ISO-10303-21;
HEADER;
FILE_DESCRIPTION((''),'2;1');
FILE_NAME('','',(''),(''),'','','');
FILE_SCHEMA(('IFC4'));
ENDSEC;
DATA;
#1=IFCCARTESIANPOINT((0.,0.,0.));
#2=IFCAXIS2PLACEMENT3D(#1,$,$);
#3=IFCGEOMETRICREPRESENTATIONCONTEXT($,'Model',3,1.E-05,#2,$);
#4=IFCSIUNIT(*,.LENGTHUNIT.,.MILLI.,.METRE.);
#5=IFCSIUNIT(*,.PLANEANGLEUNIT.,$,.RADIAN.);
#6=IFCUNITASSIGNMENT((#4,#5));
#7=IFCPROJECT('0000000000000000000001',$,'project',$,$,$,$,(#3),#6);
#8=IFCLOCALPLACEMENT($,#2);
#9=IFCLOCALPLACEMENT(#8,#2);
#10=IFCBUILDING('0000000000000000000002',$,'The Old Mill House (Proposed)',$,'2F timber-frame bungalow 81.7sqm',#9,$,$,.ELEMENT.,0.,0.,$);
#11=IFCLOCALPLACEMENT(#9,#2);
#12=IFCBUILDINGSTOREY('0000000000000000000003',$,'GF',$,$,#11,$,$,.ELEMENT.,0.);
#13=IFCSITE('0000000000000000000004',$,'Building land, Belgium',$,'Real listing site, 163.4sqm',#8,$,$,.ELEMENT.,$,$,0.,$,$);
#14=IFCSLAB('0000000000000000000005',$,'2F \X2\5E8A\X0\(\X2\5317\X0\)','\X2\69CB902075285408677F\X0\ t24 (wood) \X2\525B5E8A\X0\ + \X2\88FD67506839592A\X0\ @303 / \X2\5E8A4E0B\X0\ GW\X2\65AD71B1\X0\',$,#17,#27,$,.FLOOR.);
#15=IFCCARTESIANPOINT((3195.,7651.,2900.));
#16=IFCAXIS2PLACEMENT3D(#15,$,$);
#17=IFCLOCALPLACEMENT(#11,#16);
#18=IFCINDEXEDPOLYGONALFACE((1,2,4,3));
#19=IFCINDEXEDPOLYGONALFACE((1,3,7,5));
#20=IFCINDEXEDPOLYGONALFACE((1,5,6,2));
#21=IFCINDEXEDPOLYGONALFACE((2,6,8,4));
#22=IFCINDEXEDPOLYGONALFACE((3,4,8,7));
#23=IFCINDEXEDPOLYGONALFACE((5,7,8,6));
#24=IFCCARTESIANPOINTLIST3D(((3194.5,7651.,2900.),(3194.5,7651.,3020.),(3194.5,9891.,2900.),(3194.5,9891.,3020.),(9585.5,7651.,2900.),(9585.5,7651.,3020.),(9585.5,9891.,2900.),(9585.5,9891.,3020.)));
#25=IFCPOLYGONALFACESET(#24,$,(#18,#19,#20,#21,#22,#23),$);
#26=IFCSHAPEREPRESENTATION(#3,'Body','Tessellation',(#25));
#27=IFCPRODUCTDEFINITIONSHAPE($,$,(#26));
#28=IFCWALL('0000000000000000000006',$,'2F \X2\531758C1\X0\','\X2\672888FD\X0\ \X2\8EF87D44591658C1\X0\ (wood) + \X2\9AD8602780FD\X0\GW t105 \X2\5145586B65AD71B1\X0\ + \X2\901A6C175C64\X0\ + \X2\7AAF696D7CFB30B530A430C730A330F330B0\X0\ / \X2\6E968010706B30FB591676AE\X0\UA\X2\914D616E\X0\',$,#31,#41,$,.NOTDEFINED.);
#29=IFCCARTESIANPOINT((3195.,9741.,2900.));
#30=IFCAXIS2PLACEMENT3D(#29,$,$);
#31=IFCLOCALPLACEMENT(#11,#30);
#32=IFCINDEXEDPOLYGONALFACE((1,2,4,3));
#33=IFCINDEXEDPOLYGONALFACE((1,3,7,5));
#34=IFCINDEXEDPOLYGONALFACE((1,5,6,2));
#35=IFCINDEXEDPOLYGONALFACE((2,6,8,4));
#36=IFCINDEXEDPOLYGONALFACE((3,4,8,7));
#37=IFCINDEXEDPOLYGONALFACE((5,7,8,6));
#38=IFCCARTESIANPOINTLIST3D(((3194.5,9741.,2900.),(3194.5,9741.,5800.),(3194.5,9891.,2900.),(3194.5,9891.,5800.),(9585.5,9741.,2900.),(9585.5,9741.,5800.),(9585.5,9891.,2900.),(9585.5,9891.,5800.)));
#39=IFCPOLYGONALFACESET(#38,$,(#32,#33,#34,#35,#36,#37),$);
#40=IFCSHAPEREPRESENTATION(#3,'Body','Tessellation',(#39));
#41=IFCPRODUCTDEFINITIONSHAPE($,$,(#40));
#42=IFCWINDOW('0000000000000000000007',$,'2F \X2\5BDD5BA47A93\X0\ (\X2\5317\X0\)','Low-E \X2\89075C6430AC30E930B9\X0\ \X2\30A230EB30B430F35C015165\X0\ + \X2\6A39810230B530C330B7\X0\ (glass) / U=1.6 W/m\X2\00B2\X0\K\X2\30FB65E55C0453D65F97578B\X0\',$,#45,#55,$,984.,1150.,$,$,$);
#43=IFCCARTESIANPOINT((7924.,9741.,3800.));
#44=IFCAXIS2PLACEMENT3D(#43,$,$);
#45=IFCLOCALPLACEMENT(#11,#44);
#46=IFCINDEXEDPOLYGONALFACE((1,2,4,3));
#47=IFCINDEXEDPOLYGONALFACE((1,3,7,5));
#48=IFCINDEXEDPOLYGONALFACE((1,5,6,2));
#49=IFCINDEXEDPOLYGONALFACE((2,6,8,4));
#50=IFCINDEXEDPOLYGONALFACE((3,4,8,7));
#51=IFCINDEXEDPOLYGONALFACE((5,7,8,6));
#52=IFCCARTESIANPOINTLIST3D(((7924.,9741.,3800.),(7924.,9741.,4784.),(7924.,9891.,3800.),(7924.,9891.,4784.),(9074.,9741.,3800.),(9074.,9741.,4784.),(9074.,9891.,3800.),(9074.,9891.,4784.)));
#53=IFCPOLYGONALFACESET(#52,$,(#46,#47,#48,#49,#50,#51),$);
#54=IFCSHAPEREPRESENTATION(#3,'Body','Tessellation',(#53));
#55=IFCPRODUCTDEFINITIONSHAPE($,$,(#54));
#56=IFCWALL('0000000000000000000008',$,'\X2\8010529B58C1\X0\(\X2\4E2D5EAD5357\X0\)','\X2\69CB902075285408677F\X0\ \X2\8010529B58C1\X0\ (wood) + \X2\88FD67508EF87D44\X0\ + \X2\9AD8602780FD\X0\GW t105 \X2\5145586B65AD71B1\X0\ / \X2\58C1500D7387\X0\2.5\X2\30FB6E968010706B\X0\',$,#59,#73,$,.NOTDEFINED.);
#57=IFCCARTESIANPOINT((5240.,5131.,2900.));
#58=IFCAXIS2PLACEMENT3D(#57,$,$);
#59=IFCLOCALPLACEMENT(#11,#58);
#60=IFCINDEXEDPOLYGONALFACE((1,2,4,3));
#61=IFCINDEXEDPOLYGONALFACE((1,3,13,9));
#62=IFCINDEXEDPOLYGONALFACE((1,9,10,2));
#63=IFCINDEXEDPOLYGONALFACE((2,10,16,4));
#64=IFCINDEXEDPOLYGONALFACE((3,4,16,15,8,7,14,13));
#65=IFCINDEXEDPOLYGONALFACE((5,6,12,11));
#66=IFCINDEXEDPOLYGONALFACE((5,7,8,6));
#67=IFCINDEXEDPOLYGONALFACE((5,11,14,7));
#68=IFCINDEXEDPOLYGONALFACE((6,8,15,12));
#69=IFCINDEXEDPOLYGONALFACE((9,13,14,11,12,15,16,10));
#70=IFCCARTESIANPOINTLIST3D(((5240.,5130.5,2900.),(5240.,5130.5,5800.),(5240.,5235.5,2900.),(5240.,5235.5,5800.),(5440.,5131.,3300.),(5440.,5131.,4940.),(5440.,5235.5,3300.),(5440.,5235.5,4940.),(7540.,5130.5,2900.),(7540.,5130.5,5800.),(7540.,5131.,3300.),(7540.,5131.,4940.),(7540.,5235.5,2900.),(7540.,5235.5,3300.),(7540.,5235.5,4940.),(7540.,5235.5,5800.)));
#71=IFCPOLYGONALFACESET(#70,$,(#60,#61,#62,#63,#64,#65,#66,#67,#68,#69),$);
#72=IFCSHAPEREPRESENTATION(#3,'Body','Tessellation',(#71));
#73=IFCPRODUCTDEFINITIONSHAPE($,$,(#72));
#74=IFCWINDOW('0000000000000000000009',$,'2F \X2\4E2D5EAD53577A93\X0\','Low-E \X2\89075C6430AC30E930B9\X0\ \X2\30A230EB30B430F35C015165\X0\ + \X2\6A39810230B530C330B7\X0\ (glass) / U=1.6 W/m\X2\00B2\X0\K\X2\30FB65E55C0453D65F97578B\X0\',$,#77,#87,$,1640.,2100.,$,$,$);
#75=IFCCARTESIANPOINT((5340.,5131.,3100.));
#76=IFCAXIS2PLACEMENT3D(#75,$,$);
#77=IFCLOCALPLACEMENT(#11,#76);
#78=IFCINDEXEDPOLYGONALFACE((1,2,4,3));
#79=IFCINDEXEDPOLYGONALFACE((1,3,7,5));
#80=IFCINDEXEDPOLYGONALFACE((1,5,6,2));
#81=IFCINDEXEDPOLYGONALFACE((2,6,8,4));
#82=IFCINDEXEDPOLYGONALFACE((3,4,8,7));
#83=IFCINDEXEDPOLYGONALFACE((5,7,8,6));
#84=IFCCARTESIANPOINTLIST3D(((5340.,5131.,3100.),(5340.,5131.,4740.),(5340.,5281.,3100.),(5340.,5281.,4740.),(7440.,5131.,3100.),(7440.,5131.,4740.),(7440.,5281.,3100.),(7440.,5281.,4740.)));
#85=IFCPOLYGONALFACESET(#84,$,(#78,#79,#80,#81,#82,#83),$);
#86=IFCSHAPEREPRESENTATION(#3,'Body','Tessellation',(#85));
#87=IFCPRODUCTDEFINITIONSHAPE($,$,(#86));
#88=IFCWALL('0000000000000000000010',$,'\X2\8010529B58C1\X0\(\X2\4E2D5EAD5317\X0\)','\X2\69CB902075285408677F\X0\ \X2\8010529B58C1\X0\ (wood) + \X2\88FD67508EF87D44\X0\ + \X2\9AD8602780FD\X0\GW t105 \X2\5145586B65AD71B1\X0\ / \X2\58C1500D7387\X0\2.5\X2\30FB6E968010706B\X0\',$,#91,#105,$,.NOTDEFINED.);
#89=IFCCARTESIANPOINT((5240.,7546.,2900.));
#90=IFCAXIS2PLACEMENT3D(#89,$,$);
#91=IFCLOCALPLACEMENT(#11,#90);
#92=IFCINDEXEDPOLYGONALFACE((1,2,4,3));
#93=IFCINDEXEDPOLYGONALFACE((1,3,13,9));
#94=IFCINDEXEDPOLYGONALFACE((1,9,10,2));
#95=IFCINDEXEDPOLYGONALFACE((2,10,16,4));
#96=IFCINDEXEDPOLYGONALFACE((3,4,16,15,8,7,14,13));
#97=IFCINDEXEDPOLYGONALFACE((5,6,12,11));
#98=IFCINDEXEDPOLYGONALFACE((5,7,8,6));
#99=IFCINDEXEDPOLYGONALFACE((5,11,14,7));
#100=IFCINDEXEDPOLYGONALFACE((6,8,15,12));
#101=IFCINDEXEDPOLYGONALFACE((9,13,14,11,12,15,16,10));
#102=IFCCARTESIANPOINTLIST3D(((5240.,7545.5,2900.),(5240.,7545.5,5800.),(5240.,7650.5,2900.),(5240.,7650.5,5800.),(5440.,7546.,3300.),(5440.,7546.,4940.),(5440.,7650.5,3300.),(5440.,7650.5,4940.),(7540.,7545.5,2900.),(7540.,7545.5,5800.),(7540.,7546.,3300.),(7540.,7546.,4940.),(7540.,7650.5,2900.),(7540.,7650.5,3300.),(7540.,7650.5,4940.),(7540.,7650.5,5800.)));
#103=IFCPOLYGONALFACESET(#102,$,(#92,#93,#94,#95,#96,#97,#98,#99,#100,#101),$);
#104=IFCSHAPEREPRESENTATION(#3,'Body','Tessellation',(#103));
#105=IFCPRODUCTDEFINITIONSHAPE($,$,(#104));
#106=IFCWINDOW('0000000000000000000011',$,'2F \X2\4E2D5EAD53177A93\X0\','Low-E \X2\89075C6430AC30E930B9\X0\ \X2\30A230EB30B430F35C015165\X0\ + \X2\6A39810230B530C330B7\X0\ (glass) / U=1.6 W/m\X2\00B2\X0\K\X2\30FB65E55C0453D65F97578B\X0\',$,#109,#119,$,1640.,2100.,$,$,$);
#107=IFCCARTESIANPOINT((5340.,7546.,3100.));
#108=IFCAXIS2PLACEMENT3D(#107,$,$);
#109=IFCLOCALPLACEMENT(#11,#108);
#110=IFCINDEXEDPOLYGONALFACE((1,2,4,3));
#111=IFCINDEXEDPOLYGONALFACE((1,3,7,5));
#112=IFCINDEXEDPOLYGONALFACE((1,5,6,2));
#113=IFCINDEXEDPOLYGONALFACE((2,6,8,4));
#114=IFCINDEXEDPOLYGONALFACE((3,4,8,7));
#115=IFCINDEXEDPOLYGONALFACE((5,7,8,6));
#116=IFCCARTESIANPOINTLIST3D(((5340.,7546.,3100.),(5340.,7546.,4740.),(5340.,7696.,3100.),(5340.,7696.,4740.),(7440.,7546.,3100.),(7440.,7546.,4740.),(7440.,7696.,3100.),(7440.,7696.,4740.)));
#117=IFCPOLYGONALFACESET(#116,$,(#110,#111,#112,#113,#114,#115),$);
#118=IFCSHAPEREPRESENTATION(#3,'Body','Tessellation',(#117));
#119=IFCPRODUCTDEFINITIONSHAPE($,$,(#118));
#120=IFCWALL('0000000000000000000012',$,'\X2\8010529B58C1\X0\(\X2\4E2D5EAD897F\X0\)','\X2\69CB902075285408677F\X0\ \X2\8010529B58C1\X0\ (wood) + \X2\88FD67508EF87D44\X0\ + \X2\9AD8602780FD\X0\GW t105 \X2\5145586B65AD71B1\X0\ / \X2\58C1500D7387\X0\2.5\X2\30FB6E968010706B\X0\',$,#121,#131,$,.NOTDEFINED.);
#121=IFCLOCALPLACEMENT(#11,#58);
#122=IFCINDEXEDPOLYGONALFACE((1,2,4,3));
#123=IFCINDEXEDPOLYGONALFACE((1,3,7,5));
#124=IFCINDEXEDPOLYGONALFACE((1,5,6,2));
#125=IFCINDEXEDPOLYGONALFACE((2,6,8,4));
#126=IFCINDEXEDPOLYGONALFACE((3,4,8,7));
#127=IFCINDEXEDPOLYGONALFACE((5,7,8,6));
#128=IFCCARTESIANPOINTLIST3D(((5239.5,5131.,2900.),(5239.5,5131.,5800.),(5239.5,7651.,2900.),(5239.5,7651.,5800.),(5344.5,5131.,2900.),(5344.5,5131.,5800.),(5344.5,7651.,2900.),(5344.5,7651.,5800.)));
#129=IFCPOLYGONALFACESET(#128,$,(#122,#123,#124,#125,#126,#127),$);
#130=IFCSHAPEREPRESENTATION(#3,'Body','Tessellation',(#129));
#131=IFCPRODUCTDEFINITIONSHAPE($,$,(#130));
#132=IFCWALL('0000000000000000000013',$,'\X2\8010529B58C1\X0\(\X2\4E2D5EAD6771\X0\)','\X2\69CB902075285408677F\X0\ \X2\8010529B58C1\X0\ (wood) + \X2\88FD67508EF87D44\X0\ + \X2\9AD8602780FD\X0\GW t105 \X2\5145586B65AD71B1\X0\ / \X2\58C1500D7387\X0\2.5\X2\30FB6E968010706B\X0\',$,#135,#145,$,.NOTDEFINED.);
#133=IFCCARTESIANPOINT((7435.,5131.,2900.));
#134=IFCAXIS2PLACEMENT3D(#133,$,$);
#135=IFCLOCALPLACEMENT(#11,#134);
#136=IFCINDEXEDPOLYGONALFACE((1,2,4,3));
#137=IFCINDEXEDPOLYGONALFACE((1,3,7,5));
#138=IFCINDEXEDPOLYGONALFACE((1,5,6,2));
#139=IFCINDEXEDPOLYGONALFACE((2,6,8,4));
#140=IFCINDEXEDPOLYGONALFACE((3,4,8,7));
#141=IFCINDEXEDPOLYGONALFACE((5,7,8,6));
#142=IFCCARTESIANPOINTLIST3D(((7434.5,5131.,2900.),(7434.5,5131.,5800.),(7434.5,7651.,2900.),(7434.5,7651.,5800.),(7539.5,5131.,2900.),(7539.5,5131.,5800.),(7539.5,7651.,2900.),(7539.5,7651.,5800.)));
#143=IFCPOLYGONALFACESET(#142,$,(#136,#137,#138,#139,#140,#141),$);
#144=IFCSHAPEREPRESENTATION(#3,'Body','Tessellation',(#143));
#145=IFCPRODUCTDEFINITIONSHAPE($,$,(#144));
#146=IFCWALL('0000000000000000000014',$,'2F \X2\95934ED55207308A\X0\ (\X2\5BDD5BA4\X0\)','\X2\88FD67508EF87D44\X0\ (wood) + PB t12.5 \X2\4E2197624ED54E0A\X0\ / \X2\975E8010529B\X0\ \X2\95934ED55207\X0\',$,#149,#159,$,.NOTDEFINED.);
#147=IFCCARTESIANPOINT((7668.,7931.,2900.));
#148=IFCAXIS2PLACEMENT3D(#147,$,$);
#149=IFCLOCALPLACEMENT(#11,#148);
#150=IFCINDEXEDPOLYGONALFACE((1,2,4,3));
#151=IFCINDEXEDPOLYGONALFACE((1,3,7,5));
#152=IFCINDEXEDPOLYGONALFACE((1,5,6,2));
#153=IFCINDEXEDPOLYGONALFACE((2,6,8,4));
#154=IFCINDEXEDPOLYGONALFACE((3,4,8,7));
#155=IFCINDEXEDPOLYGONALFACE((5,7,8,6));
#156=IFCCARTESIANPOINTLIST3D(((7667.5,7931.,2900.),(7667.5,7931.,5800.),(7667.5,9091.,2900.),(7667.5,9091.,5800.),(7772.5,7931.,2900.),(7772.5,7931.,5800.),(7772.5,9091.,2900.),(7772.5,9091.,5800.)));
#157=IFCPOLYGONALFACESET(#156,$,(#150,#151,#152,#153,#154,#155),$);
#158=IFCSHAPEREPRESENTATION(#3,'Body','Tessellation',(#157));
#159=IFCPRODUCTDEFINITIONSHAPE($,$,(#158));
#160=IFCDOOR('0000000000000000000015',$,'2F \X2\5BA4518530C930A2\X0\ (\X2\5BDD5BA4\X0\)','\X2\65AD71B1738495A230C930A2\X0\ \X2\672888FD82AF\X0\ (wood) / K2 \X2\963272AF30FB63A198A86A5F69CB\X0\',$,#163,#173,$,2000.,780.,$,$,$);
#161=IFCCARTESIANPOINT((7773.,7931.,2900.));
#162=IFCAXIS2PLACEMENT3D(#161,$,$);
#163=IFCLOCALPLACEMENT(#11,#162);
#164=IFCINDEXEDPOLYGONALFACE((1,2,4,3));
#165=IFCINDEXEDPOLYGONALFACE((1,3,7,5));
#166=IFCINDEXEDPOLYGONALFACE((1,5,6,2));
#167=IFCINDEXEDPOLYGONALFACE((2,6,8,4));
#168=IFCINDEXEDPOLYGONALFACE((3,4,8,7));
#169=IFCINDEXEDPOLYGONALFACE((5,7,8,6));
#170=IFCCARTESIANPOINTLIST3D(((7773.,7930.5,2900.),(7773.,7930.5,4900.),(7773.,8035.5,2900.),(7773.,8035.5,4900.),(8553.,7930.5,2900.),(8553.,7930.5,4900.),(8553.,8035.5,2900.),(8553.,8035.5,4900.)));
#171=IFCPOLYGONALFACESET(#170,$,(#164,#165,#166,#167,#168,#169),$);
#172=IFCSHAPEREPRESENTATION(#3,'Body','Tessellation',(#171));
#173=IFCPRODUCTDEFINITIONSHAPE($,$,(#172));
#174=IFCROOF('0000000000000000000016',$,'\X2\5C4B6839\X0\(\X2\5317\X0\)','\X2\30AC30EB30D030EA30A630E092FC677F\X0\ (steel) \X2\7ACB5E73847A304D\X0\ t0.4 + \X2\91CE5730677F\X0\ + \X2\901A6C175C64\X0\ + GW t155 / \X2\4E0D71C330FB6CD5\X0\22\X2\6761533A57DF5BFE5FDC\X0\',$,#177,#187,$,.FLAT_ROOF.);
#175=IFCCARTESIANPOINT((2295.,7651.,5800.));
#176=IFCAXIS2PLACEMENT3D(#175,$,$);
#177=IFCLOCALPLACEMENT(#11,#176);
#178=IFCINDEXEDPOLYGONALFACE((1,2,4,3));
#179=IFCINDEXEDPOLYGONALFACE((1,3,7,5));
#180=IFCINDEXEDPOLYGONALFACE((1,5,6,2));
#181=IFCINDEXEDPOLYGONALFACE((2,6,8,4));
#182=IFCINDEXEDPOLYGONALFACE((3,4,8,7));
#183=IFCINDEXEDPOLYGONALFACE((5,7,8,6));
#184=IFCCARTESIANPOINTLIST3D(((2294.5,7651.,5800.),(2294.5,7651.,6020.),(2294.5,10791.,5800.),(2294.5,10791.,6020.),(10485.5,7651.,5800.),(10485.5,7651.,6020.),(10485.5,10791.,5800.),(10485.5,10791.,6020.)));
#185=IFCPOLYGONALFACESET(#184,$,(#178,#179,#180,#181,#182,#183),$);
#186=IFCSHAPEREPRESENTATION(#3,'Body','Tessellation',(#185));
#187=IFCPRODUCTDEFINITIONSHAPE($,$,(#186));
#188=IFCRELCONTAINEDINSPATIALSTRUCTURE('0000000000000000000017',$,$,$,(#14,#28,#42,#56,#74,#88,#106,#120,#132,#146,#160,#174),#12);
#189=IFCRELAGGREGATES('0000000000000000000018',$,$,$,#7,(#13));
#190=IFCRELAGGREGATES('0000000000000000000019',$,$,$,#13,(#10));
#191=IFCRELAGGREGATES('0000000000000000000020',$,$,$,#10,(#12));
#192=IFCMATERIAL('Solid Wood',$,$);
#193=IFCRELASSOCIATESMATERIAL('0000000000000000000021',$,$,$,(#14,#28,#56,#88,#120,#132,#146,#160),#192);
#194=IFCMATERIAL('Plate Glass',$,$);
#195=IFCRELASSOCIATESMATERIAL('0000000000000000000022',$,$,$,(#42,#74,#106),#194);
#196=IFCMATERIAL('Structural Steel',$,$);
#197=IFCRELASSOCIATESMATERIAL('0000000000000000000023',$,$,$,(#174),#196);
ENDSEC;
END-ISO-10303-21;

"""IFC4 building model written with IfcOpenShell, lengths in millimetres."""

from ifc_helpers import new_model, si_unit, frame, frame_2d, origin, place, context, project, spatial, rectangle, extrude, material, element, fill, save


model = new_model("IFC4")

# Units and contexts
model_context = context("Model", 3, precision=1e-05, world=origin())
ifc_project = project(units=[si_unit("LENGTHUNIT", "METRE", prefix="MILLI"), si_unit("PLANEANGLEUNIT", "RADIAN")], contexts=[model_context])

# Site, building, storey
site_placement = place(None, origin())
site = spatial("IfcSite", under=ifc_project, at=site_placement, Name="Building land, Belgium", ObjectType="Real listing site, 163.4sqm", CompositionType="ELEMENT", RefElevation=0.0)
building_placement = place(site_placement, origin())
building = spatial("IfcBuilding", under=site, at=building_placement, Name="The Old Mill House (Proposed)", ObjectType="2F timber-frame bungalow 81.7sqm", CompositionType="ELEMENT", ElevationOfRefHeight=0.0, ElevationOfTerrain=0.0)
storey_placement = place(building_placement, origin())
storey = spatial("IfcBuildingStorey", under=building, at=storey_placement, Name="GF", CompositionType="ELEMENT", Elevation=0.0)

# Slab
ifc_material_1 = material(Name="Solid Wood")
slab_placement = place(storey_placement, frame((3195.0, 7651.0, 2900.0)))
element("IfcSlab", 1, at=slab_placement, inside=storey, material=ifc_material_1, Name="2F 床(北)", Description="構造用合板 t24 (wood) 剛床 + 製材根太 @303 / 床下 GW断熱", PredefinedType="FLOOR", context=model_context, shape_type="SweptSolid", body=[
    extrude(rectangle(XDim=6391.0, YDim=2240.0, at=frame_2d((3195.0, 1120.0))), frame((3195.0, 7651.0, 2900.0)), (0.0, 0.0, 1.0), 120.0),
])

# Walls, openings, windows
wall_1_placement = place(storey_placement, frame((3195.0, 9741.0, 2900.0)))
wall_1 = element("IfcWall", 2, at=wall_1_placement, inside=storey, material=ifc_material_1, Name="2F 北壁", Description="木製 軸組外壁 (wood) + 高性能GW t105 充填断熱 + 通気層 + 窯業系サイディング / 準耐火・外皮UA配慮", PredefinedType="NOTDEFINED", context=model_context, shape_type="SweptSolid", body=[
    extrude(rectangle(XDim=6391.0, YDim=150.0, at=frame_2d((3195.0, 75.0))), frame((3195.0, 9741.0, 2900.0)), (0.0, 0.0, 1.0), 2900.0),
])
opening_1_placement = place(storey_placement, frame((7924.0, 9741.0, 3800.0)))
opening_1 = element("IfcOpeningElement", 3, at=opening_1_placement, cuts=wall_1, PredefinedType="NOTDEFINED", context=model_context, shape_type="SweptSolid", body=[
    extrude(rectangle(XDim=1150.0, YDim=150.0, at=frame_2d((575.0, 75.0))), frame((7924.0, 9741.0, 3800.0)), (0.0, 0.0, 1.0), 984.0),
])
ifc_material_2 = material(Name="Plate Glass")
window_1_placement = place(storey_placement, frame((7924.0, 9741.0, 3800.0)))
window_1 = element("IfcWindow", 4, at=window_1_placement, inside=storey, material=ifc_material_2, Name="2F 寝室窓 (北)", Description="Low-E 複層ガラス アルゴン封入 + 樹脂サッシ (glass) / U=1.6 W/m²K・日射取得型", OverallHeight=984.0, OverallWidth=1150.0, context=model_context, shape_type="SweptSolid", body=[
    extrude(rectangle(XDim=1150.0, YDim=150.0, at=frame_2d((575.0, 75.0))), frame((7924.0, 9741.0, 3800.0)), (0.0, 0.0, 1.0), 984.0),
])
fill(opening_1, window_1)
wall_2_placement = place(storey_placement, frame((5240.0, 5131.0, 2900.0)))
wall_2 = element("IfcWall", 5, at=wall_2_placement, inside=storey, material=ifc_material_1, Name="耐力壁(中庭南)", Description="構造用合板 耐力壁 (wood) + 製材軸組 + 高性能GW t105 充填断熱 / 壁倍率2.5・準耐火", PredefinedType="NOTDEFINED", context=model_context, shape_type="SweptSolid", body=[
    extrude(rectangle(XDim=2300.0, YDim=105.0, at=frame_2d((1150.0, 52.0))), frame((5240.0, 5131.0, 2900.0)), (0.0, 0.0, 1.0), 2900.0),
])
opening_2_placement = place(storey_placement, frame((5340.0, 5131.0, 3100.0)))
opening_2 = element("IfcOpeningElement", 6, at=opening_2_placement, cuts=wall_2, PredefinedType="NOTDEFINED", context=model_context, shape_type="SweptSolid", body=[
    extrude(rectangle(XDim=2100.0, YDim=150.0, at=frame_2d((1050.0, 75.0))), frame((5340.0, 5131.0, 3100.0)), (0.0, 0.0, 1.0), 1640.0),
])
window_2_placement = place(storey_placement, frame((5340.0, 5131.0, 3100.0)))
window_2 = element("IfcWindow", 7, at=window_2_placement, inside=storey, material=ifc_material_2, Name="2F 中庭南窓", Description="Low-E 複層ガラス アルゴン封入 + 樹脂サッシ (glass) / U=1.6 W/m²K・日射取得型", OverallHeight=1640.0, OverallWidth=2100.0, context=model_context, shape_type="SweptSolid", body=[
    extrude(rectangle(XDim=2100.0, YDim=150.0, at=frame_2d((1050.0, 75.0))), frame((5340.0, 5131.0, 3100.0)), (0.0, 0.0, 1.0), 1640.0),
])
fill(opening_2, window_2)
wall_3_placement = place(storey_placement, frame((5240.0, 7546.0, 2900.0)))
wall_3 = element("IfcWall", 8, at=wall_3_placement, inside=storey, material=ifc_material_1, Name="耐力壁(中庭北)", Description="構造用合板 耐力壁 (wood) + 製材軸組 + 高性能GW t105 充填断熱 / 壁倍率2.5・準耐火", PredefinedType="NOTDEFINED", context=model_context, shape_type="SweptSolid", body=[
    extrude(rectangle(XDim=2300.0, YDim=105.0, at=frame_2d((1150.0, 52.0))), frame((5240.0, 7546.0, 2900.0)), (0.0, 0.0, 1.0), 2900.0),
])
opening_3_placement = place(storey_placement, frame((5340.0, 7546.0, 3100.0)))
opening_3 = element("IfcOpeningElement", 9, at=opening_3_placement, cuts=wall_3, PredefinedType="NOTDEFINED", context=model_context, shape_type="SweptSolid", body=[
    extrude(rectangle(XDim=2100.0, YDim=150.0, at=frame_2d((1050.0, 75.0))), frame((5340.0, 7546.0, 3100.0)), (0.0, 0.0, 1.0), 1640.0),
])
window_3_placement = place(storey_placement, frame((5340.0, 7546.0, 3100.0)))
window_3 = element("IfcWindow", 10, at=window_3_placement, inside=storey, material=ifc_material_2, Name="2F 中庭北窓", Description="Low-E 複層ガラス アルゴン封入 + 樹脂サッシ (glass) / U=1.6 W/m²K・日射取得型", OverallHeight=1640.0, OverallWidth=2100.0, context=model_context, shape_type="SweptSolid", body=[
    extrude(rectangle(XDim=2100.0, YDim=150.0, at=frame_2d((1050.0, 75.0))), frame((5340.0, 7546.0, 3100.0)), (0.0, 0.0, 1.0), 1640.0),
])
fill(opening_3, window_3)

# Walls
wall_4_placement = place(storey_placement, frame((5240.0, 5131.0, 2900.0)))
element("IfcWall", 11, at=wall_4_placement, inside=storey, material=ifc_material_1, Name="耐力壁(中庭西)", Description="構造用合板 耐力壁 (wood) + 製材軸組 + 高性能GW t105 充填断熱 / 壁倍率2.5・準耐火", PredefinedType="NOTDEFINED", context=model_context, shape_type="SweptSolid", body=[
    extrude(rectangle(XDim=105.0, YDim=2520.0, at=frame_2d((52.0, 1260.0))), frame((5240.0, 5131.0, 2900.0)), (0.0, 0.0, 1.0), 2900.0),
])
wall_5_placement = place(storey_placement, frame((7435.0, 5131.0, 2900.0)))
element("IfcWall", 12, at=wall_5_placement, inside=storey, material=ifc_material_1, Name="耐力壁(中庭東)", Description="構造用合板 耐力壁 (wood) + 製材軸組 + 高性能GW t105 充填断熱 / 壁倍率2.5・準耐火", PredefinedType="NOTDEFINED", context=model_context, shape_type="SweptSolid", body=[
    extrude(rectangle(XDim=105.0, YDim=2520.0, at=frame_2d((52.0, 1260.0))), frame((7435.0, 5131.0, 2900.0)), (0.0, 0.0, 1.0), 2900.0),
])
wall_6_placement = place(storey_placement, frame((7668.0, 7931.0, 2900.0)))
element("IfcWall", 13, at=wall_6_placement, inside=storey, material=ifc_material_1, Name="2F 間仕切り (寝室)", Description="製材軸組 (wood) + PB t12.5 両面仕上 / 非耐力 間仕切", PredefinedType="NOTDEFINED", context=model_context, shape_type="SweptSolid", body=[
    extrude(rectangle(XDim=105.0, YDim=1160.0, at=frame_2d((52.0, 580.0))), frame((7668.0, 7931.0, 2900.0)), (0.0, 0.0, 1.0), 2900.0),
])

# Door
door_placement = place(storey_placement, frame((7773.0, 7931.0, 2900.0)))
element("IfcDoor", 14, at=door_placement, inside=storey, material=ifc_material_1, Name="2F 室内ドア (寝室)", Description="断熱玄関ドア 木製芯 (wood) / K2 防犯・採風機構", OverallHeight=2000.0, OverallWidth=780.0, context=model_context, shape_type="SweptSolid", body=[
    extrude(rectangle(XDim=780.0, YDim=105.0, at=frame_2d((390.0, 52.0))), frame((7773.0, 7931.0, 2900.0)), (0.0, 0.0, 1.0), 2000.0),
])

# Roof
ifc_material_3 = material(Name="Structural Steel")
for number, where, name in (
    (15, (2295.0, 7651.0, 5800.0), "屋根(北)"),
):
    element("IfcRoof", number, at=place(storey_placement, frame(where)), inside=storey, material=ifc_material_3, Name=name, Description="ガルバリウム鋼板 (steel) 立平葺き t0.4 + 野地板 + 通気層 + GW t155 / 不燃・法22条区域対応", PredefinedType="FLAT_ROOF", context=model_context, shape_type="SweptSolid", body=[
        extrude(rectangle(XDim=8191.0, YDim=3140.0, at=frame_2d((4095.0, 1570.0))), frame((2295.0, 7651.0, 5800.0)), (0.0, 0.0, 1.0), 220.0),
    ])

save(model, "model.ifc")
